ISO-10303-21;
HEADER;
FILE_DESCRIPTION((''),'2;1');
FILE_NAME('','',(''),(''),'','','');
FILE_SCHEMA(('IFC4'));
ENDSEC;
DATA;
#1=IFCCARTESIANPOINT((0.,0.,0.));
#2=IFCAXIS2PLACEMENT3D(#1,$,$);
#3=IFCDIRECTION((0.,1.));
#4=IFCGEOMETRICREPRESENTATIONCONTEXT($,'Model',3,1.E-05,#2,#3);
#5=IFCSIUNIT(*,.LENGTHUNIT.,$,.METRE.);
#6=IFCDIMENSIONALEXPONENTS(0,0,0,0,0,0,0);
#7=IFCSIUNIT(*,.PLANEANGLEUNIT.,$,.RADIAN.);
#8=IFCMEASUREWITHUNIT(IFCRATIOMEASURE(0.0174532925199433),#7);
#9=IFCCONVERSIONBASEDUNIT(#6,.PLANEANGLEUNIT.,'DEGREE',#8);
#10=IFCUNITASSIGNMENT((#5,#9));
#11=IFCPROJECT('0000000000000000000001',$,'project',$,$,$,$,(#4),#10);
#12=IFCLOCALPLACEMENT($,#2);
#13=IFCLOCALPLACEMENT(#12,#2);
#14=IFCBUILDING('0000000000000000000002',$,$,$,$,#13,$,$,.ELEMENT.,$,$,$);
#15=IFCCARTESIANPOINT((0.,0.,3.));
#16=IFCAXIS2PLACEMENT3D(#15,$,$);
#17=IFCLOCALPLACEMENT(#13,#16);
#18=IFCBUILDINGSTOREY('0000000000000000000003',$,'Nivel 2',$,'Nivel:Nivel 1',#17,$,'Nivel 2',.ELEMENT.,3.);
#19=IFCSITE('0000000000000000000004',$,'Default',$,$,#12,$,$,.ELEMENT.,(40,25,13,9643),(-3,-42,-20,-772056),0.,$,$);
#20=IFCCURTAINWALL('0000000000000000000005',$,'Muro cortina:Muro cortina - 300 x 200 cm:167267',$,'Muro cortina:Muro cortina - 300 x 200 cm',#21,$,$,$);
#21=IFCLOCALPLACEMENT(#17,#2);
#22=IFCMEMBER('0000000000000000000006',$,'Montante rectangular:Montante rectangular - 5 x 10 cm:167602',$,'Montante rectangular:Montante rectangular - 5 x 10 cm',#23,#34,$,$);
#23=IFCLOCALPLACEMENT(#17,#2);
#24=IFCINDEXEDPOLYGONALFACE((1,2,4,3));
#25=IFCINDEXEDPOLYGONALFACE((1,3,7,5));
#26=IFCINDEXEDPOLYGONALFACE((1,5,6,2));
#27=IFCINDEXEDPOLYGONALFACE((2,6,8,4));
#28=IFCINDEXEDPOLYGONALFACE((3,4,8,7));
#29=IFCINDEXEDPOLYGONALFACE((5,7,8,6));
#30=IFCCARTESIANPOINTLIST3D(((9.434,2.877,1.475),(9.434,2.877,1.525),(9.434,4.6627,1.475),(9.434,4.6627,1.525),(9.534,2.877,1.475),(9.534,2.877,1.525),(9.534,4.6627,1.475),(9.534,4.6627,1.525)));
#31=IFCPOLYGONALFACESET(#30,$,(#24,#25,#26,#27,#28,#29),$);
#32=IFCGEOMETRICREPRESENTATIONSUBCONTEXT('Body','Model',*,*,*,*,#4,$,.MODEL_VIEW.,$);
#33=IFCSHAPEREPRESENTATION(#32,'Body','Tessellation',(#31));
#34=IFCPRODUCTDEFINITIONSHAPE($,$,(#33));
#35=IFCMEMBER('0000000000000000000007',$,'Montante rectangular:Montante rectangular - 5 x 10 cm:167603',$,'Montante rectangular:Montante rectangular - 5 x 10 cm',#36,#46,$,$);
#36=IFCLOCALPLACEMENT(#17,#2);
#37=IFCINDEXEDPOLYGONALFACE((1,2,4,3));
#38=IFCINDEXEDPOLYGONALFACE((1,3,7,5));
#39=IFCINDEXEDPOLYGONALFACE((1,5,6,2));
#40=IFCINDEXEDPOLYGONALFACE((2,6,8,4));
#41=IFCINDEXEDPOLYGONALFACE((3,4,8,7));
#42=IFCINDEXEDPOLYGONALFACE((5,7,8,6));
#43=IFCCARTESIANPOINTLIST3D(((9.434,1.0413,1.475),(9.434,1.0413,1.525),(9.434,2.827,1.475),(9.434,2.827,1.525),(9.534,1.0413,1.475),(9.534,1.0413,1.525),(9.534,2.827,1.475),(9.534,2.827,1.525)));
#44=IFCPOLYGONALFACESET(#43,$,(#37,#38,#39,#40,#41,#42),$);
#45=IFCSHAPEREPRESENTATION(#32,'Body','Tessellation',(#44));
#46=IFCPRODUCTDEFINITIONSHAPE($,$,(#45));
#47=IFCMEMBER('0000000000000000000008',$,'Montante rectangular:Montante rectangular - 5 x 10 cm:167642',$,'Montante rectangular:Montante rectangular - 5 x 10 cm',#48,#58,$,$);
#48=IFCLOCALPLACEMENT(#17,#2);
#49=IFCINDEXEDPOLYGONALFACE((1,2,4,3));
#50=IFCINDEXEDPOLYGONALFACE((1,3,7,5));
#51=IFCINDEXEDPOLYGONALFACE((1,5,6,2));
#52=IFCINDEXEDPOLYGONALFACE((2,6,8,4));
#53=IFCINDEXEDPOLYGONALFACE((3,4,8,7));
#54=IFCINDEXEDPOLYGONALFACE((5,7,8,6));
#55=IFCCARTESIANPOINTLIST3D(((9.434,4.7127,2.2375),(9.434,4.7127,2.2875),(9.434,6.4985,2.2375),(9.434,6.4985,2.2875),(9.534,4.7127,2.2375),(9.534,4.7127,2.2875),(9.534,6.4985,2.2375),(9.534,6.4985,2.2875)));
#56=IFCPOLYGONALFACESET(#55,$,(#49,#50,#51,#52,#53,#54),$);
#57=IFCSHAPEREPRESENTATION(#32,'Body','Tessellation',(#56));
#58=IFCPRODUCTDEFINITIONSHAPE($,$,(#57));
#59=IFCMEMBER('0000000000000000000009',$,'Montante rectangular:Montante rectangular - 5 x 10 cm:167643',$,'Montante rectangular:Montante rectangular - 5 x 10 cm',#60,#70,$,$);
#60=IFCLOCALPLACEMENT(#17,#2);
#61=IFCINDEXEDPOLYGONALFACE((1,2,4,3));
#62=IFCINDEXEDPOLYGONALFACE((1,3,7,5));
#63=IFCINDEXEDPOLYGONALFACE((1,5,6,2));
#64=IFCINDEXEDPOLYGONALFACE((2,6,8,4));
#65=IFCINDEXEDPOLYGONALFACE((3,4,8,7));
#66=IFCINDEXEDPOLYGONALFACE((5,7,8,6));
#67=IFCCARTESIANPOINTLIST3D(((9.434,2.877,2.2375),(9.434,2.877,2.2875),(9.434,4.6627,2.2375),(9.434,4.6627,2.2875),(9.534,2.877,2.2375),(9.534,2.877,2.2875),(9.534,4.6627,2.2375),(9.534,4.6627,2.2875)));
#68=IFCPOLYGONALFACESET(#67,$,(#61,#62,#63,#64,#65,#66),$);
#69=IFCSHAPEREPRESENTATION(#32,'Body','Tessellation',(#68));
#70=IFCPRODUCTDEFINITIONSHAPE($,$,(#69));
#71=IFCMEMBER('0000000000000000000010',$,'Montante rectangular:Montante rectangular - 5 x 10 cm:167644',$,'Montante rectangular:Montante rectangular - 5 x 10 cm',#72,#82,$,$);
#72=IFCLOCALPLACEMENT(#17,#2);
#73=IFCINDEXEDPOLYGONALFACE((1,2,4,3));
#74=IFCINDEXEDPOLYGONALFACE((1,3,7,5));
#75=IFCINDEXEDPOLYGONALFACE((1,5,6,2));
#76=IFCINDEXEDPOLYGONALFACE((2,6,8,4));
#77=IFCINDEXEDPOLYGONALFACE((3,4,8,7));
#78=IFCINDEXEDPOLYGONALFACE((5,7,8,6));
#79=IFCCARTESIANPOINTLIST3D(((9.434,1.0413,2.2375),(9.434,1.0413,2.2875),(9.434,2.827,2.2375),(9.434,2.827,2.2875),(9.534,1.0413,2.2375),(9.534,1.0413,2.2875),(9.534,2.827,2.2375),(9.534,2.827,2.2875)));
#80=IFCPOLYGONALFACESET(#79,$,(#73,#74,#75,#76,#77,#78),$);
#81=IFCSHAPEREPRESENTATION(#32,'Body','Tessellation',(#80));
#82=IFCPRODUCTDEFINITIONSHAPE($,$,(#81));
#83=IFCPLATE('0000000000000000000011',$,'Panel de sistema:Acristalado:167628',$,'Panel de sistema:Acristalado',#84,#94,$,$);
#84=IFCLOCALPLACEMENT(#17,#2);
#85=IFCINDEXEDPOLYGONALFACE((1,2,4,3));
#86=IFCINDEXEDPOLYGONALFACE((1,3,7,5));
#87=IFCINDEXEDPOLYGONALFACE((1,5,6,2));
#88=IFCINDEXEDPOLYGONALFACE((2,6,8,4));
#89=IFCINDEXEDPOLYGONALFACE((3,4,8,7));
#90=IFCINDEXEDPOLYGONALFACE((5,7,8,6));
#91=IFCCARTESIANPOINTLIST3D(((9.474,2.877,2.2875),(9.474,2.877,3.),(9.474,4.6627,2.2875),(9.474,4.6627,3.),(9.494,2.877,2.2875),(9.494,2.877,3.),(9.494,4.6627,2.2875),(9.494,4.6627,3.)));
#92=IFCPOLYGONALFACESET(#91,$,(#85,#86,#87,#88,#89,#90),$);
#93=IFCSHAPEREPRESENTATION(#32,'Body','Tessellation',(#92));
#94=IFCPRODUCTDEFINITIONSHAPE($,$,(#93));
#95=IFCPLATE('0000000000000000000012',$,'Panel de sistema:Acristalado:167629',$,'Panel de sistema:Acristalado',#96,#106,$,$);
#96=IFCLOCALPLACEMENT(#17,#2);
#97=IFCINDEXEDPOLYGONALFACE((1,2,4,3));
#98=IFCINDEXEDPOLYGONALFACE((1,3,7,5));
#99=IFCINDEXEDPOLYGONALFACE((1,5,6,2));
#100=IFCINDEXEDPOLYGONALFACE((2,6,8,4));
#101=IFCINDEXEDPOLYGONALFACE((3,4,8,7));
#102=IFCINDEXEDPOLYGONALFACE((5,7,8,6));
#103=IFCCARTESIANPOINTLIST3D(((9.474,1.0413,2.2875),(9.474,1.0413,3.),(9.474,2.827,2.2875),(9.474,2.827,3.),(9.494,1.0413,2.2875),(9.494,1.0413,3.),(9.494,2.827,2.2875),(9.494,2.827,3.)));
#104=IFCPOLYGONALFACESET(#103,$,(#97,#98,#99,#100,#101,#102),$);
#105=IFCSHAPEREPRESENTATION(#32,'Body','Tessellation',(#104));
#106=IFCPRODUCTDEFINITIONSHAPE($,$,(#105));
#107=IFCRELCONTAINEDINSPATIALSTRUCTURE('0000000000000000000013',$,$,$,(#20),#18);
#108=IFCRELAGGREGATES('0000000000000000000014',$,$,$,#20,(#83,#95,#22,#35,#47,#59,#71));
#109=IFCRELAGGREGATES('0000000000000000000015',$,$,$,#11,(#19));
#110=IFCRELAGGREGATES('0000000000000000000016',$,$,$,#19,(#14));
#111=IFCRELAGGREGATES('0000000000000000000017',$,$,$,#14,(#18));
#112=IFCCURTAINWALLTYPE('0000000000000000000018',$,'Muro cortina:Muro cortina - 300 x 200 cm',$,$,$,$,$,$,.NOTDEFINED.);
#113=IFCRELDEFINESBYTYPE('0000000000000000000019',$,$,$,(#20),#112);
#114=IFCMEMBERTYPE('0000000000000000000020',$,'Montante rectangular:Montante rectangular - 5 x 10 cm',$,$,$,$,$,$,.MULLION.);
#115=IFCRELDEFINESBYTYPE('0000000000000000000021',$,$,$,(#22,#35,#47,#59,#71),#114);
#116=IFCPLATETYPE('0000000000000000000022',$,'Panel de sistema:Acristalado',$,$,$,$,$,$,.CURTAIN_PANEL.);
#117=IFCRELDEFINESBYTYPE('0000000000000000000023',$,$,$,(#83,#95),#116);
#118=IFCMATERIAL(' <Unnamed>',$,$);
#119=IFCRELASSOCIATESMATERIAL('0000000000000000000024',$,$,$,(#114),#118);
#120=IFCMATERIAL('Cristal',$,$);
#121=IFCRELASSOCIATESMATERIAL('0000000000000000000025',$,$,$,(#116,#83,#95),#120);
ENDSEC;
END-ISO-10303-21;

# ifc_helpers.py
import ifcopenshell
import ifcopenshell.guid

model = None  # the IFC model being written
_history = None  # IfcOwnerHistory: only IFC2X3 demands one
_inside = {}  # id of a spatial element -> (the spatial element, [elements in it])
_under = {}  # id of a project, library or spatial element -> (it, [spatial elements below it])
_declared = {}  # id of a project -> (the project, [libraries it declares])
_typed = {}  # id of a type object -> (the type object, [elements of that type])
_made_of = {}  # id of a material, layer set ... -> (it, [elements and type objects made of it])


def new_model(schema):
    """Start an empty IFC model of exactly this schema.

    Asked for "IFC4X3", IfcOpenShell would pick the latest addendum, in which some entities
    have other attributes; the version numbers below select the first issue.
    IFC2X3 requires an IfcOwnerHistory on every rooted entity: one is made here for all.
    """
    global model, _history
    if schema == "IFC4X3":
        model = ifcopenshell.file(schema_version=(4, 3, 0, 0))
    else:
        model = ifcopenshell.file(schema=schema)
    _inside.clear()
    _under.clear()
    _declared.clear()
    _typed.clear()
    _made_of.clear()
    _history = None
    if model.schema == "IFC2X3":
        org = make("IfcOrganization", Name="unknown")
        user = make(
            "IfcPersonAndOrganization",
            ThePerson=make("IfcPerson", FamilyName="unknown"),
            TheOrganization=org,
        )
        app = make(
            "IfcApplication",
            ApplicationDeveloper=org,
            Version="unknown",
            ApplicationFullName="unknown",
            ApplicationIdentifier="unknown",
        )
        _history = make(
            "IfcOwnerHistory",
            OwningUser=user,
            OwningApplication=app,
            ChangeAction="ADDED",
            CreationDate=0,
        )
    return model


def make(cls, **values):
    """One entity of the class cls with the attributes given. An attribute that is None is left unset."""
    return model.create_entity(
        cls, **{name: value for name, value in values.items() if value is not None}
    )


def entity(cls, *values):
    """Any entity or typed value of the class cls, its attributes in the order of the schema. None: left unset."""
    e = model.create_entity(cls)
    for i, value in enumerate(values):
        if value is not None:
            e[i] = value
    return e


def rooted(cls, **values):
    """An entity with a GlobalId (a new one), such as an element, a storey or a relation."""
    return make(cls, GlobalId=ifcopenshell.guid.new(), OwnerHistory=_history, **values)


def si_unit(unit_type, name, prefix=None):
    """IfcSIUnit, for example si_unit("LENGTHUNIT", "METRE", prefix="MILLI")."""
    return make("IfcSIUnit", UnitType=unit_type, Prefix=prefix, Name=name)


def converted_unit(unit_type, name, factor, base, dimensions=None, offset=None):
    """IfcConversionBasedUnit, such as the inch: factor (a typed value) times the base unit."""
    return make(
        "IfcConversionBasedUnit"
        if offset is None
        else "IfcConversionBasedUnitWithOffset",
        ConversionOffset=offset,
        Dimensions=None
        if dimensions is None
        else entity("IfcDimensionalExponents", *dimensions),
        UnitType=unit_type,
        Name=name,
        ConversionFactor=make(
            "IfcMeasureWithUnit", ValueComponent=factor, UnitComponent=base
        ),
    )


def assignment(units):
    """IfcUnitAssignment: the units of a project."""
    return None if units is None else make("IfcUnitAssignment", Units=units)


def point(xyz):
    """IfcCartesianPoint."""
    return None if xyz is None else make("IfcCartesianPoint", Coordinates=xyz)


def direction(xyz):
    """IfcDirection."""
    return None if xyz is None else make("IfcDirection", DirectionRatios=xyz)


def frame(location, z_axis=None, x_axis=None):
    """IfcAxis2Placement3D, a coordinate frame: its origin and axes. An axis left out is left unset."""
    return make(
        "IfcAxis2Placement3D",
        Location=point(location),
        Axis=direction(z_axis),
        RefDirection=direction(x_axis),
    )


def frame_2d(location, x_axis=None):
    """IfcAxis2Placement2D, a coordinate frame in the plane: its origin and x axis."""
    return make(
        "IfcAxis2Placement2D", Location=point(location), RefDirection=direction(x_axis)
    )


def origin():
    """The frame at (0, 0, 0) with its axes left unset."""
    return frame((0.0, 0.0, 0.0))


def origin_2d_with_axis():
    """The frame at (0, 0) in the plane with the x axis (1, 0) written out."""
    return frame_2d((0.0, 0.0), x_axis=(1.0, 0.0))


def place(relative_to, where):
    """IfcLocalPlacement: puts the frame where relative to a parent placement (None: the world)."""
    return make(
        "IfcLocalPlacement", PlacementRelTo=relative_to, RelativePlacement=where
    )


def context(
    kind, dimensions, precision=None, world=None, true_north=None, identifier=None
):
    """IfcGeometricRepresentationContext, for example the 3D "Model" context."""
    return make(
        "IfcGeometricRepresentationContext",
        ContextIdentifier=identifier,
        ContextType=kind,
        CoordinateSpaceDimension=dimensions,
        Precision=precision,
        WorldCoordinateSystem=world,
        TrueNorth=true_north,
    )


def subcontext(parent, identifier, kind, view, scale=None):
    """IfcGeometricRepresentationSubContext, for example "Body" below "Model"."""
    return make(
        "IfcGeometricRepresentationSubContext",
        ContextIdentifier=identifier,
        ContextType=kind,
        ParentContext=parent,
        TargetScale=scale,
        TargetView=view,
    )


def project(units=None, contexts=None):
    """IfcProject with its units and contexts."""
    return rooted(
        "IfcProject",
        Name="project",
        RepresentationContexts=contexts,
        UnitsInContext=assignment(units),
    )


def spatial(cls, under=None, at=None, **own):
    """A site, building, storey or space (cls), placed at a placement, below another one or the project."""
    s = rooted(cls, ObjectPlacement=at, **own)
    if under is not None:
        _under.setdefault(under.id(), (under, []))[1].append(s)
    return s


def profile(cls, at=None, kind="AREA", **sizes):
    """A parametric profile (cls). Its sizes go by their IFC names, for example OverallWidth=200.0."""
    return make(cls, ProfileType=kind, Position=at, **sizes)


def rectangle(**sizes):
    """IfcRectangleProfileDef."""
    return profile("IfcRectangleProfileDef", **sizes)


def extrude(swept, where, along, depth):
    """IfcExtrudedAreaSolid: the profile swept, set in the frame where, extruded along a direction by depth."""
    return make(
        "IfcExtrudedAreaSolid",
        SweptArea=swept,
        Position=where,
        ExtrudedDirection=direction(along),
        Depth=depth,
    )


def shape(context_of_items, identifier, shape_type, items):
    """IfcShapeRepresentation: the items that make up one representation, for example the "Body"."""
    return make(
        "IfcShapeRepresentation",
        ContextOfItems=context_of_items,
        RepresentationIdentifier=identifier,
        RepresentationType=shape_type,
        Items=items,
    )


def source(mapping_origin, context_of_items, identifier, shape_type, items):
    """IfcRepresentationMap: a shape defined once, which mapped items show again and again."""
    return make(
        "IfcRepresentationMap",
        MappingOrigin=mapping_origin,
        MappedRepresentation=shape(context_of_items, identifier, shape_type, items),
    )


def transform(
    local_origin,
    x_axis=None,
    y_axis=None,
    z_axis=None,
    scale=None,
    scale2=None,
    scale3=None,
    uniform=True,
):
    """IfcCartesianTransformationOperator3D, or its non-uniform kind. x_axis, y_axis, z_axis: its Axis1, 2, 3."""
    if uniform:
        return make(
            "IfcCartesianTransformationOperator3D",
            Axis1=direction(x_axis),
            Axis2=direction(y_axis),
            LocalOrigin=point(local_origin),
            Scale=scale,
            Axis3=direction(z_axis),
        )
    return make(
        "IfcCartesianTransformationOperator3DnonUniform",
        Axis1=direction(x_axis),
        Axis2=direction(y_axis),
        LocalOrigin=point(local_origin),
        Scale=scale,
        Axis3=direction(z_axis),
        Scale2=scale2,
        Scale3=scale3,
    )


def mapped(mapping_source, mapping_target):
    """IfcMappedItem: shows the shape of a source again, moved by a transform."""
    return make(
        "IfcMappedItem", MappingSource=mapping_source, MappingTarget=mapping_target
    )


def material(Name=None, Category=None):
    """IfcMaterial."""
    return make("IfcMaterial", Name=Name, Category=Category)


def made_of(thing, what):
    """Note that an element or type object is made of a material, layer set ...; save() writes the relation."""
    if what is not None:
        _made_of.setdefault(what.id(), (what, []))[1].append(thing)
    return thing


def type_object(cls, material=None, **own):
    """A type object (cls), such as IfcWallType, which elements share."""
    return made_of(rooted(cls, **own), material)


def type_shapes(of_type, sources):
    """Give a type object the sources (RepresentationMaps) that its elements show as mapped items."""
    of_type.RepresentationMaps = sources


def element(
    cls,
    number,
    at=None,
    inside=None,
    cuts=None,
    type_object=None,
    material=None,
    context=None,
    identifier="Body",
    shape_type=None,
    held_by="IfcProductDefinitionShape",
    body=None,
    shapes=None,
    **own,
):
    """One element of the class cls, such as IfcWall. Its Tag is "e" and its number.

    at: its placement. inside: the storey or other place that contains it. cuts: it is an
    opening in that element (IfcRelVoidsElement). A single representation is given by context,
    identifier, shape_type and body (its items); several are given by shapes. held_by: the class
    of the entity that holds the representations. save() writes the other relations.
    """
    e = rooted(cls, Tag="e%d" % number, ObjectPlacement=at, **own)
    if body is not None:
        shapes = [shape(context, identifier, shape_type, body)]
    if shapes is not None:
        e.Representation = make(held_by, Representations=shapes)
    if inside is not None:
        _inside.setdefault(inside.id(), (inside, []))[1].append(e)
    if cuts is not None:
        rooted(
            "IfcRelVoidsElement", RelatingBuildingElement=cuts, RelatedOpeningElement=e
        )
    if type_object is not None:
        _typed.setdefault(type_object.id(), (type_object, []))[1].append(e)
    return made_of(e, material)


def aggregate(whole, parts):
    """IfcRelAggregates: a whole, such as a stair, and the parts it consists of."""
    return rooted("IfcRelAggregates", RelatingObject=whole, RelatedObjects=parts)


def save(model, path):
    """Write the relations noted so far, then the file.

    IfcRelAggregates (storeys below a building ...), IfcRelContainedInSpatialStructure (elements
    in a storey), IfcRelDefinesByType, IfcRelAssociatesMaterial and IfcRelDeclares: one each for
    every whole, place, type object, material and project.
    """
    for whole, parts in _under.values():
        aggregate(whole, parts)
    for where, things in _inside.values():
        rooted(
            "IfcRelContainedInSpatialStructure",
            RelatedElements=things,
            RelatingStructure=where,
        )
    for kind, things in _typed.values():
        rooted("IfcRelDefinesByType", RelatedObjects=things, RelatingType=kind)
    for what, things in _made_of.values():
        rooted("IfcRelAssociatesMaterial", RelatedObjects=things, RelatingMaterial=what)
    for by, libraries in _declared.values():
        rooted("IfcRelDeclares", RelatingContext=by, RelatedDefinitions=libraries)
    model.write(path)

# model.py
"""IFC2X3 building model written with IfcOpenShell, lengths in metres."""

from ifc_helpers import new_model, entity, si_unit, converted_unit, direction, frame, origin, origin_2d_with_axis, place, context, subcontext, project, spatial, rectangle, extrude, source, transform, mapped, material, type_object, type_shapes, element, aggregate, save


model = new_model("IFC2X3")

# Units and contexts
model_context = context("Model", 3, precision=1e-05, world=origin(), true_north=direction((0.0, 1.0)))
body_context = subcontext(model_context, "Body", "Model", "MODEL_VIEW")
ifc_project = project(units=[si_unit("LENGTHUNIT", "METRE"), converted_unit("PLANEANGLEUNIT", "DEGREE", entity("IfcRatioMeasure", 0.0174532925199433), si_unit("PLANEANGLEUNIT", "RADIAN"), dimensions=[0, 0, 0, 0, 0, 0, 0])], contexts=[model_context])

# Site, building, storey
site_placement = place(None, origin())
site = spatial("IfcSite", under=ifc_project, at=site_placement, Name="Default", CompositionType="ELEMENT", RefLatitude=(40, 25, 13, 9643), RefLongitude=(-3, -42, -20, -772056), RefElevation=0.0)
building_placement = place(site_placement, origin())
building = spatial("IfcBuilding", under=site, at=building_placement, CompositionType="ELEMENT")
storey_placement = place(building_placement, frame((0.0, 0.0, 3.0)))
storey = spatial("IfcBuildingStorey", under=building, at=storey_placement, Name="Nivel 2", ObjectType="Nivel:Nivel 1", LongName="Nivel 2", CompositionType="ELEMENT", Elevation=3.0)

# Curtain wall, members, plates
curtain_wall_type = type_object("IfcCurtainWallType", Name="Muro cortina:Muro cortina - 300 x 200 cm", PredefinedType="NOTDEFINED")
curtain_wall_placement = place(storey_placement, frame((0.0, 0.0, -3.0)))
curtain_wall = element("IfcCurtainWall", 1, at=curtain_wall_placement, inside=storey, type_object=curtain_wall_type, Name="Muro cortina:Muro cortina - 300 x 200 cm:167267", ObjectType="Muro cortina:Muro cortina - 300 x 200 cm")
ifc_material_1 = material(Name=" <Unnamed>")
member_type_1 = type_object("IfcMemberType", Name="Montante rectangular:Montante rectangular - 5 x 10 cm", PredefinedType="MULLION", material=ifc_material_1)
shared_shape_1 = source(origin(), body_context, "Body", "SweptSolid", [
    extrude(rectangle(XDim=0.1, YDim=0.05, at=origin_2d_with_axis()), frame((0.0, 0.0, -1.7857), z_axis=(0.0, 0.0, 1.0), x_axis=(0.0, -1.0, 0.0)), (0.0, 0.0, 1.0), 1.7857),
])
type_shapes(member_type_1, [shared_shape_1])
member_1_placement = place(storey_placement, frame((9.484, 2.877, 1.5), z_axis=(0.0, -1.0, 0.0), x_axis=(0.0, 0.0, 1.0)))
member_1 = element("IfcMember", 2, at=member_1_placement, type_object=member_type_1, Name="Montante rectangular:Montante rectangular - 5 x 10 cm:167602", ObjectType="Montante rectangular:Montante rectangular - 5 x 10 cm", context=body_context, shape_type="MappedRepresentation", body=[
    mapped(shared_shape_1, transform((0.0, 0.0, 0.0), scale=1.0)),
])
member_2_placement = place(storey_placement, frame((9.484, 1.0413, 1.5), z_axis=(0.0, -1.0, 0.0), x_axis=(0.0, 0.0, 1.0)))
member_2 = element("IfcMember", 3, at=member_2_placement, type_object=member_type_1, Name="Montante rectangular:Montante rectangular - 5 x 10 cm:167603", ObjectType="Montante rectangular:Montante rectangular - 5 x 10 cm", context=body_context, shape_type="MappedRepresentation", body=[
    mapped(shared_shape_1, transform((0.0, 0.0, 0.0), scale=1.0)),
])
member_3_placement = place(storey_placement, frame((9.484, 4.7127, 2.2625), z_axis=(0.0, -1.0, 0.0), x_axis=(0.0, 0.0, 1.0)))
member_3 = element("IfcMember", 4, at=member_3_placement, type_object=member_type_1, Name="Montante rectangular:Montante rectangular - 5 x 10 cm:167642", ObjectType="Montante rectangular:Montante rectangular - 5 x 10 cm", context=body_context, shape_type="MappedRepresentation", body=[
    mapped(shared_shape_1, transform((0.0, 0.0, 0.0), scale=1.0)),
])
member_4_placement = place(storey_placement, frame((9.484, 2.877, 2.2625), z_axis=(0.0, -1.0, 0.0), x_axis=(0.0, 0.0, 1.0)))
member_4 = element("IfcMember", 5, at=member_4_placement, type_object=member_type_1, Name="Montante rectangular:Montante rectangular - 5 x 10 cm:167643", ObjectType="Montante rectangular:Montante rectangular - 5 x 10 cm", context=body_context, shape_type="MappedRepresentation", body=[
    mapped(shared_shape_1, transform((0.0, 0.0, 0.0), scale=1.0)),
])
member_5_placement = place(storey_placement, frame((9.484, 1.0413, 2.2625), z_axis=(0.0, -1.0, 0.0), x_axis=(0.0, 0.0, 1.0)))
member_5 = element("IfcMember", 6, at=member_5_placement, type_object=member_type_1, Name="Montante rectangular:Montante rectangular - 5 x 10 cm:167644", ObjectType="Montante rectangular:Montante rectangular - 5 x 10 cm", context=body_context, shape_type="MappedRepresentation", body=[
    mapped(shared_shape_1, transform((0.0, 0.0, 0.0), scale=1.0)),
])
ifc_material_2 = material(Name="Cristal")
plate_type = type_object("IfcPlateType", Name="Panel de sistema:Acristalado", PredefinedType="CURTAIN_PANEL", material=ifc_material_2)
shared_shape_2 = source(origin(), body_context, "Body", "SweptSolid", [
    extrude(rectangle(XDim=0.02, YDim=1.7857, at=origin_2d_with_axis()), frame((0.0, 0.0, 0.0), z_axis=(0.0, 0.0, 1.0), x_axis=(0.0, 1.0, 0.0)), (0.0, 0.0, 1.0), 0.7125),
])
type_shapes(plate_type, [shared_shape_2])
plate_1_placement = place(curtain_wall_placement, frame((9.484, 3.7699, 5.2875), z_axis=(0.0, 0.0, 1.0), x_axis=(0.0, -1.0, 0.0)))
plate_1 = element("IfcPlate", 7, at=plate_1_placement, type_object=plate_type, material=ifc_material_2, Name="Panel de sistema:Acristalado:167628", ObjectType="Panel de sistema:Acristalado", context=body_context, shape_type="MappedRepresentation", body=[
    mapped(shared_shape_2, transform((0.0, 0.0, 0.0), scale=1.0)),
])
plate_2_placement = place(curtain_wall_placement, frame((9.484, 1.9342, 5.2875), z_axis=(0.0, 0.0, 1.0), x_axis=(0.0, -1.0, 0.0)))
plate_2 = element("IfcPlate", 8, at=plate_2_placement, type_object=plate_type, material=ifc_material_2, Name="Panel de sistema:Acristalado:167629", ObjectType="Panel de sistema:Acristalado", context=body_context, shape_type="MappedRepresentation", body=[
    mapped(shared_shape_2, transform((0.0, 0.0, 0.0), scale=1.0)),
])
aggregate(curtain_wall, [plate_1, plate_2, member_1, member_2, member_3, member_4, member_5])

save(model, "model.ifc")
